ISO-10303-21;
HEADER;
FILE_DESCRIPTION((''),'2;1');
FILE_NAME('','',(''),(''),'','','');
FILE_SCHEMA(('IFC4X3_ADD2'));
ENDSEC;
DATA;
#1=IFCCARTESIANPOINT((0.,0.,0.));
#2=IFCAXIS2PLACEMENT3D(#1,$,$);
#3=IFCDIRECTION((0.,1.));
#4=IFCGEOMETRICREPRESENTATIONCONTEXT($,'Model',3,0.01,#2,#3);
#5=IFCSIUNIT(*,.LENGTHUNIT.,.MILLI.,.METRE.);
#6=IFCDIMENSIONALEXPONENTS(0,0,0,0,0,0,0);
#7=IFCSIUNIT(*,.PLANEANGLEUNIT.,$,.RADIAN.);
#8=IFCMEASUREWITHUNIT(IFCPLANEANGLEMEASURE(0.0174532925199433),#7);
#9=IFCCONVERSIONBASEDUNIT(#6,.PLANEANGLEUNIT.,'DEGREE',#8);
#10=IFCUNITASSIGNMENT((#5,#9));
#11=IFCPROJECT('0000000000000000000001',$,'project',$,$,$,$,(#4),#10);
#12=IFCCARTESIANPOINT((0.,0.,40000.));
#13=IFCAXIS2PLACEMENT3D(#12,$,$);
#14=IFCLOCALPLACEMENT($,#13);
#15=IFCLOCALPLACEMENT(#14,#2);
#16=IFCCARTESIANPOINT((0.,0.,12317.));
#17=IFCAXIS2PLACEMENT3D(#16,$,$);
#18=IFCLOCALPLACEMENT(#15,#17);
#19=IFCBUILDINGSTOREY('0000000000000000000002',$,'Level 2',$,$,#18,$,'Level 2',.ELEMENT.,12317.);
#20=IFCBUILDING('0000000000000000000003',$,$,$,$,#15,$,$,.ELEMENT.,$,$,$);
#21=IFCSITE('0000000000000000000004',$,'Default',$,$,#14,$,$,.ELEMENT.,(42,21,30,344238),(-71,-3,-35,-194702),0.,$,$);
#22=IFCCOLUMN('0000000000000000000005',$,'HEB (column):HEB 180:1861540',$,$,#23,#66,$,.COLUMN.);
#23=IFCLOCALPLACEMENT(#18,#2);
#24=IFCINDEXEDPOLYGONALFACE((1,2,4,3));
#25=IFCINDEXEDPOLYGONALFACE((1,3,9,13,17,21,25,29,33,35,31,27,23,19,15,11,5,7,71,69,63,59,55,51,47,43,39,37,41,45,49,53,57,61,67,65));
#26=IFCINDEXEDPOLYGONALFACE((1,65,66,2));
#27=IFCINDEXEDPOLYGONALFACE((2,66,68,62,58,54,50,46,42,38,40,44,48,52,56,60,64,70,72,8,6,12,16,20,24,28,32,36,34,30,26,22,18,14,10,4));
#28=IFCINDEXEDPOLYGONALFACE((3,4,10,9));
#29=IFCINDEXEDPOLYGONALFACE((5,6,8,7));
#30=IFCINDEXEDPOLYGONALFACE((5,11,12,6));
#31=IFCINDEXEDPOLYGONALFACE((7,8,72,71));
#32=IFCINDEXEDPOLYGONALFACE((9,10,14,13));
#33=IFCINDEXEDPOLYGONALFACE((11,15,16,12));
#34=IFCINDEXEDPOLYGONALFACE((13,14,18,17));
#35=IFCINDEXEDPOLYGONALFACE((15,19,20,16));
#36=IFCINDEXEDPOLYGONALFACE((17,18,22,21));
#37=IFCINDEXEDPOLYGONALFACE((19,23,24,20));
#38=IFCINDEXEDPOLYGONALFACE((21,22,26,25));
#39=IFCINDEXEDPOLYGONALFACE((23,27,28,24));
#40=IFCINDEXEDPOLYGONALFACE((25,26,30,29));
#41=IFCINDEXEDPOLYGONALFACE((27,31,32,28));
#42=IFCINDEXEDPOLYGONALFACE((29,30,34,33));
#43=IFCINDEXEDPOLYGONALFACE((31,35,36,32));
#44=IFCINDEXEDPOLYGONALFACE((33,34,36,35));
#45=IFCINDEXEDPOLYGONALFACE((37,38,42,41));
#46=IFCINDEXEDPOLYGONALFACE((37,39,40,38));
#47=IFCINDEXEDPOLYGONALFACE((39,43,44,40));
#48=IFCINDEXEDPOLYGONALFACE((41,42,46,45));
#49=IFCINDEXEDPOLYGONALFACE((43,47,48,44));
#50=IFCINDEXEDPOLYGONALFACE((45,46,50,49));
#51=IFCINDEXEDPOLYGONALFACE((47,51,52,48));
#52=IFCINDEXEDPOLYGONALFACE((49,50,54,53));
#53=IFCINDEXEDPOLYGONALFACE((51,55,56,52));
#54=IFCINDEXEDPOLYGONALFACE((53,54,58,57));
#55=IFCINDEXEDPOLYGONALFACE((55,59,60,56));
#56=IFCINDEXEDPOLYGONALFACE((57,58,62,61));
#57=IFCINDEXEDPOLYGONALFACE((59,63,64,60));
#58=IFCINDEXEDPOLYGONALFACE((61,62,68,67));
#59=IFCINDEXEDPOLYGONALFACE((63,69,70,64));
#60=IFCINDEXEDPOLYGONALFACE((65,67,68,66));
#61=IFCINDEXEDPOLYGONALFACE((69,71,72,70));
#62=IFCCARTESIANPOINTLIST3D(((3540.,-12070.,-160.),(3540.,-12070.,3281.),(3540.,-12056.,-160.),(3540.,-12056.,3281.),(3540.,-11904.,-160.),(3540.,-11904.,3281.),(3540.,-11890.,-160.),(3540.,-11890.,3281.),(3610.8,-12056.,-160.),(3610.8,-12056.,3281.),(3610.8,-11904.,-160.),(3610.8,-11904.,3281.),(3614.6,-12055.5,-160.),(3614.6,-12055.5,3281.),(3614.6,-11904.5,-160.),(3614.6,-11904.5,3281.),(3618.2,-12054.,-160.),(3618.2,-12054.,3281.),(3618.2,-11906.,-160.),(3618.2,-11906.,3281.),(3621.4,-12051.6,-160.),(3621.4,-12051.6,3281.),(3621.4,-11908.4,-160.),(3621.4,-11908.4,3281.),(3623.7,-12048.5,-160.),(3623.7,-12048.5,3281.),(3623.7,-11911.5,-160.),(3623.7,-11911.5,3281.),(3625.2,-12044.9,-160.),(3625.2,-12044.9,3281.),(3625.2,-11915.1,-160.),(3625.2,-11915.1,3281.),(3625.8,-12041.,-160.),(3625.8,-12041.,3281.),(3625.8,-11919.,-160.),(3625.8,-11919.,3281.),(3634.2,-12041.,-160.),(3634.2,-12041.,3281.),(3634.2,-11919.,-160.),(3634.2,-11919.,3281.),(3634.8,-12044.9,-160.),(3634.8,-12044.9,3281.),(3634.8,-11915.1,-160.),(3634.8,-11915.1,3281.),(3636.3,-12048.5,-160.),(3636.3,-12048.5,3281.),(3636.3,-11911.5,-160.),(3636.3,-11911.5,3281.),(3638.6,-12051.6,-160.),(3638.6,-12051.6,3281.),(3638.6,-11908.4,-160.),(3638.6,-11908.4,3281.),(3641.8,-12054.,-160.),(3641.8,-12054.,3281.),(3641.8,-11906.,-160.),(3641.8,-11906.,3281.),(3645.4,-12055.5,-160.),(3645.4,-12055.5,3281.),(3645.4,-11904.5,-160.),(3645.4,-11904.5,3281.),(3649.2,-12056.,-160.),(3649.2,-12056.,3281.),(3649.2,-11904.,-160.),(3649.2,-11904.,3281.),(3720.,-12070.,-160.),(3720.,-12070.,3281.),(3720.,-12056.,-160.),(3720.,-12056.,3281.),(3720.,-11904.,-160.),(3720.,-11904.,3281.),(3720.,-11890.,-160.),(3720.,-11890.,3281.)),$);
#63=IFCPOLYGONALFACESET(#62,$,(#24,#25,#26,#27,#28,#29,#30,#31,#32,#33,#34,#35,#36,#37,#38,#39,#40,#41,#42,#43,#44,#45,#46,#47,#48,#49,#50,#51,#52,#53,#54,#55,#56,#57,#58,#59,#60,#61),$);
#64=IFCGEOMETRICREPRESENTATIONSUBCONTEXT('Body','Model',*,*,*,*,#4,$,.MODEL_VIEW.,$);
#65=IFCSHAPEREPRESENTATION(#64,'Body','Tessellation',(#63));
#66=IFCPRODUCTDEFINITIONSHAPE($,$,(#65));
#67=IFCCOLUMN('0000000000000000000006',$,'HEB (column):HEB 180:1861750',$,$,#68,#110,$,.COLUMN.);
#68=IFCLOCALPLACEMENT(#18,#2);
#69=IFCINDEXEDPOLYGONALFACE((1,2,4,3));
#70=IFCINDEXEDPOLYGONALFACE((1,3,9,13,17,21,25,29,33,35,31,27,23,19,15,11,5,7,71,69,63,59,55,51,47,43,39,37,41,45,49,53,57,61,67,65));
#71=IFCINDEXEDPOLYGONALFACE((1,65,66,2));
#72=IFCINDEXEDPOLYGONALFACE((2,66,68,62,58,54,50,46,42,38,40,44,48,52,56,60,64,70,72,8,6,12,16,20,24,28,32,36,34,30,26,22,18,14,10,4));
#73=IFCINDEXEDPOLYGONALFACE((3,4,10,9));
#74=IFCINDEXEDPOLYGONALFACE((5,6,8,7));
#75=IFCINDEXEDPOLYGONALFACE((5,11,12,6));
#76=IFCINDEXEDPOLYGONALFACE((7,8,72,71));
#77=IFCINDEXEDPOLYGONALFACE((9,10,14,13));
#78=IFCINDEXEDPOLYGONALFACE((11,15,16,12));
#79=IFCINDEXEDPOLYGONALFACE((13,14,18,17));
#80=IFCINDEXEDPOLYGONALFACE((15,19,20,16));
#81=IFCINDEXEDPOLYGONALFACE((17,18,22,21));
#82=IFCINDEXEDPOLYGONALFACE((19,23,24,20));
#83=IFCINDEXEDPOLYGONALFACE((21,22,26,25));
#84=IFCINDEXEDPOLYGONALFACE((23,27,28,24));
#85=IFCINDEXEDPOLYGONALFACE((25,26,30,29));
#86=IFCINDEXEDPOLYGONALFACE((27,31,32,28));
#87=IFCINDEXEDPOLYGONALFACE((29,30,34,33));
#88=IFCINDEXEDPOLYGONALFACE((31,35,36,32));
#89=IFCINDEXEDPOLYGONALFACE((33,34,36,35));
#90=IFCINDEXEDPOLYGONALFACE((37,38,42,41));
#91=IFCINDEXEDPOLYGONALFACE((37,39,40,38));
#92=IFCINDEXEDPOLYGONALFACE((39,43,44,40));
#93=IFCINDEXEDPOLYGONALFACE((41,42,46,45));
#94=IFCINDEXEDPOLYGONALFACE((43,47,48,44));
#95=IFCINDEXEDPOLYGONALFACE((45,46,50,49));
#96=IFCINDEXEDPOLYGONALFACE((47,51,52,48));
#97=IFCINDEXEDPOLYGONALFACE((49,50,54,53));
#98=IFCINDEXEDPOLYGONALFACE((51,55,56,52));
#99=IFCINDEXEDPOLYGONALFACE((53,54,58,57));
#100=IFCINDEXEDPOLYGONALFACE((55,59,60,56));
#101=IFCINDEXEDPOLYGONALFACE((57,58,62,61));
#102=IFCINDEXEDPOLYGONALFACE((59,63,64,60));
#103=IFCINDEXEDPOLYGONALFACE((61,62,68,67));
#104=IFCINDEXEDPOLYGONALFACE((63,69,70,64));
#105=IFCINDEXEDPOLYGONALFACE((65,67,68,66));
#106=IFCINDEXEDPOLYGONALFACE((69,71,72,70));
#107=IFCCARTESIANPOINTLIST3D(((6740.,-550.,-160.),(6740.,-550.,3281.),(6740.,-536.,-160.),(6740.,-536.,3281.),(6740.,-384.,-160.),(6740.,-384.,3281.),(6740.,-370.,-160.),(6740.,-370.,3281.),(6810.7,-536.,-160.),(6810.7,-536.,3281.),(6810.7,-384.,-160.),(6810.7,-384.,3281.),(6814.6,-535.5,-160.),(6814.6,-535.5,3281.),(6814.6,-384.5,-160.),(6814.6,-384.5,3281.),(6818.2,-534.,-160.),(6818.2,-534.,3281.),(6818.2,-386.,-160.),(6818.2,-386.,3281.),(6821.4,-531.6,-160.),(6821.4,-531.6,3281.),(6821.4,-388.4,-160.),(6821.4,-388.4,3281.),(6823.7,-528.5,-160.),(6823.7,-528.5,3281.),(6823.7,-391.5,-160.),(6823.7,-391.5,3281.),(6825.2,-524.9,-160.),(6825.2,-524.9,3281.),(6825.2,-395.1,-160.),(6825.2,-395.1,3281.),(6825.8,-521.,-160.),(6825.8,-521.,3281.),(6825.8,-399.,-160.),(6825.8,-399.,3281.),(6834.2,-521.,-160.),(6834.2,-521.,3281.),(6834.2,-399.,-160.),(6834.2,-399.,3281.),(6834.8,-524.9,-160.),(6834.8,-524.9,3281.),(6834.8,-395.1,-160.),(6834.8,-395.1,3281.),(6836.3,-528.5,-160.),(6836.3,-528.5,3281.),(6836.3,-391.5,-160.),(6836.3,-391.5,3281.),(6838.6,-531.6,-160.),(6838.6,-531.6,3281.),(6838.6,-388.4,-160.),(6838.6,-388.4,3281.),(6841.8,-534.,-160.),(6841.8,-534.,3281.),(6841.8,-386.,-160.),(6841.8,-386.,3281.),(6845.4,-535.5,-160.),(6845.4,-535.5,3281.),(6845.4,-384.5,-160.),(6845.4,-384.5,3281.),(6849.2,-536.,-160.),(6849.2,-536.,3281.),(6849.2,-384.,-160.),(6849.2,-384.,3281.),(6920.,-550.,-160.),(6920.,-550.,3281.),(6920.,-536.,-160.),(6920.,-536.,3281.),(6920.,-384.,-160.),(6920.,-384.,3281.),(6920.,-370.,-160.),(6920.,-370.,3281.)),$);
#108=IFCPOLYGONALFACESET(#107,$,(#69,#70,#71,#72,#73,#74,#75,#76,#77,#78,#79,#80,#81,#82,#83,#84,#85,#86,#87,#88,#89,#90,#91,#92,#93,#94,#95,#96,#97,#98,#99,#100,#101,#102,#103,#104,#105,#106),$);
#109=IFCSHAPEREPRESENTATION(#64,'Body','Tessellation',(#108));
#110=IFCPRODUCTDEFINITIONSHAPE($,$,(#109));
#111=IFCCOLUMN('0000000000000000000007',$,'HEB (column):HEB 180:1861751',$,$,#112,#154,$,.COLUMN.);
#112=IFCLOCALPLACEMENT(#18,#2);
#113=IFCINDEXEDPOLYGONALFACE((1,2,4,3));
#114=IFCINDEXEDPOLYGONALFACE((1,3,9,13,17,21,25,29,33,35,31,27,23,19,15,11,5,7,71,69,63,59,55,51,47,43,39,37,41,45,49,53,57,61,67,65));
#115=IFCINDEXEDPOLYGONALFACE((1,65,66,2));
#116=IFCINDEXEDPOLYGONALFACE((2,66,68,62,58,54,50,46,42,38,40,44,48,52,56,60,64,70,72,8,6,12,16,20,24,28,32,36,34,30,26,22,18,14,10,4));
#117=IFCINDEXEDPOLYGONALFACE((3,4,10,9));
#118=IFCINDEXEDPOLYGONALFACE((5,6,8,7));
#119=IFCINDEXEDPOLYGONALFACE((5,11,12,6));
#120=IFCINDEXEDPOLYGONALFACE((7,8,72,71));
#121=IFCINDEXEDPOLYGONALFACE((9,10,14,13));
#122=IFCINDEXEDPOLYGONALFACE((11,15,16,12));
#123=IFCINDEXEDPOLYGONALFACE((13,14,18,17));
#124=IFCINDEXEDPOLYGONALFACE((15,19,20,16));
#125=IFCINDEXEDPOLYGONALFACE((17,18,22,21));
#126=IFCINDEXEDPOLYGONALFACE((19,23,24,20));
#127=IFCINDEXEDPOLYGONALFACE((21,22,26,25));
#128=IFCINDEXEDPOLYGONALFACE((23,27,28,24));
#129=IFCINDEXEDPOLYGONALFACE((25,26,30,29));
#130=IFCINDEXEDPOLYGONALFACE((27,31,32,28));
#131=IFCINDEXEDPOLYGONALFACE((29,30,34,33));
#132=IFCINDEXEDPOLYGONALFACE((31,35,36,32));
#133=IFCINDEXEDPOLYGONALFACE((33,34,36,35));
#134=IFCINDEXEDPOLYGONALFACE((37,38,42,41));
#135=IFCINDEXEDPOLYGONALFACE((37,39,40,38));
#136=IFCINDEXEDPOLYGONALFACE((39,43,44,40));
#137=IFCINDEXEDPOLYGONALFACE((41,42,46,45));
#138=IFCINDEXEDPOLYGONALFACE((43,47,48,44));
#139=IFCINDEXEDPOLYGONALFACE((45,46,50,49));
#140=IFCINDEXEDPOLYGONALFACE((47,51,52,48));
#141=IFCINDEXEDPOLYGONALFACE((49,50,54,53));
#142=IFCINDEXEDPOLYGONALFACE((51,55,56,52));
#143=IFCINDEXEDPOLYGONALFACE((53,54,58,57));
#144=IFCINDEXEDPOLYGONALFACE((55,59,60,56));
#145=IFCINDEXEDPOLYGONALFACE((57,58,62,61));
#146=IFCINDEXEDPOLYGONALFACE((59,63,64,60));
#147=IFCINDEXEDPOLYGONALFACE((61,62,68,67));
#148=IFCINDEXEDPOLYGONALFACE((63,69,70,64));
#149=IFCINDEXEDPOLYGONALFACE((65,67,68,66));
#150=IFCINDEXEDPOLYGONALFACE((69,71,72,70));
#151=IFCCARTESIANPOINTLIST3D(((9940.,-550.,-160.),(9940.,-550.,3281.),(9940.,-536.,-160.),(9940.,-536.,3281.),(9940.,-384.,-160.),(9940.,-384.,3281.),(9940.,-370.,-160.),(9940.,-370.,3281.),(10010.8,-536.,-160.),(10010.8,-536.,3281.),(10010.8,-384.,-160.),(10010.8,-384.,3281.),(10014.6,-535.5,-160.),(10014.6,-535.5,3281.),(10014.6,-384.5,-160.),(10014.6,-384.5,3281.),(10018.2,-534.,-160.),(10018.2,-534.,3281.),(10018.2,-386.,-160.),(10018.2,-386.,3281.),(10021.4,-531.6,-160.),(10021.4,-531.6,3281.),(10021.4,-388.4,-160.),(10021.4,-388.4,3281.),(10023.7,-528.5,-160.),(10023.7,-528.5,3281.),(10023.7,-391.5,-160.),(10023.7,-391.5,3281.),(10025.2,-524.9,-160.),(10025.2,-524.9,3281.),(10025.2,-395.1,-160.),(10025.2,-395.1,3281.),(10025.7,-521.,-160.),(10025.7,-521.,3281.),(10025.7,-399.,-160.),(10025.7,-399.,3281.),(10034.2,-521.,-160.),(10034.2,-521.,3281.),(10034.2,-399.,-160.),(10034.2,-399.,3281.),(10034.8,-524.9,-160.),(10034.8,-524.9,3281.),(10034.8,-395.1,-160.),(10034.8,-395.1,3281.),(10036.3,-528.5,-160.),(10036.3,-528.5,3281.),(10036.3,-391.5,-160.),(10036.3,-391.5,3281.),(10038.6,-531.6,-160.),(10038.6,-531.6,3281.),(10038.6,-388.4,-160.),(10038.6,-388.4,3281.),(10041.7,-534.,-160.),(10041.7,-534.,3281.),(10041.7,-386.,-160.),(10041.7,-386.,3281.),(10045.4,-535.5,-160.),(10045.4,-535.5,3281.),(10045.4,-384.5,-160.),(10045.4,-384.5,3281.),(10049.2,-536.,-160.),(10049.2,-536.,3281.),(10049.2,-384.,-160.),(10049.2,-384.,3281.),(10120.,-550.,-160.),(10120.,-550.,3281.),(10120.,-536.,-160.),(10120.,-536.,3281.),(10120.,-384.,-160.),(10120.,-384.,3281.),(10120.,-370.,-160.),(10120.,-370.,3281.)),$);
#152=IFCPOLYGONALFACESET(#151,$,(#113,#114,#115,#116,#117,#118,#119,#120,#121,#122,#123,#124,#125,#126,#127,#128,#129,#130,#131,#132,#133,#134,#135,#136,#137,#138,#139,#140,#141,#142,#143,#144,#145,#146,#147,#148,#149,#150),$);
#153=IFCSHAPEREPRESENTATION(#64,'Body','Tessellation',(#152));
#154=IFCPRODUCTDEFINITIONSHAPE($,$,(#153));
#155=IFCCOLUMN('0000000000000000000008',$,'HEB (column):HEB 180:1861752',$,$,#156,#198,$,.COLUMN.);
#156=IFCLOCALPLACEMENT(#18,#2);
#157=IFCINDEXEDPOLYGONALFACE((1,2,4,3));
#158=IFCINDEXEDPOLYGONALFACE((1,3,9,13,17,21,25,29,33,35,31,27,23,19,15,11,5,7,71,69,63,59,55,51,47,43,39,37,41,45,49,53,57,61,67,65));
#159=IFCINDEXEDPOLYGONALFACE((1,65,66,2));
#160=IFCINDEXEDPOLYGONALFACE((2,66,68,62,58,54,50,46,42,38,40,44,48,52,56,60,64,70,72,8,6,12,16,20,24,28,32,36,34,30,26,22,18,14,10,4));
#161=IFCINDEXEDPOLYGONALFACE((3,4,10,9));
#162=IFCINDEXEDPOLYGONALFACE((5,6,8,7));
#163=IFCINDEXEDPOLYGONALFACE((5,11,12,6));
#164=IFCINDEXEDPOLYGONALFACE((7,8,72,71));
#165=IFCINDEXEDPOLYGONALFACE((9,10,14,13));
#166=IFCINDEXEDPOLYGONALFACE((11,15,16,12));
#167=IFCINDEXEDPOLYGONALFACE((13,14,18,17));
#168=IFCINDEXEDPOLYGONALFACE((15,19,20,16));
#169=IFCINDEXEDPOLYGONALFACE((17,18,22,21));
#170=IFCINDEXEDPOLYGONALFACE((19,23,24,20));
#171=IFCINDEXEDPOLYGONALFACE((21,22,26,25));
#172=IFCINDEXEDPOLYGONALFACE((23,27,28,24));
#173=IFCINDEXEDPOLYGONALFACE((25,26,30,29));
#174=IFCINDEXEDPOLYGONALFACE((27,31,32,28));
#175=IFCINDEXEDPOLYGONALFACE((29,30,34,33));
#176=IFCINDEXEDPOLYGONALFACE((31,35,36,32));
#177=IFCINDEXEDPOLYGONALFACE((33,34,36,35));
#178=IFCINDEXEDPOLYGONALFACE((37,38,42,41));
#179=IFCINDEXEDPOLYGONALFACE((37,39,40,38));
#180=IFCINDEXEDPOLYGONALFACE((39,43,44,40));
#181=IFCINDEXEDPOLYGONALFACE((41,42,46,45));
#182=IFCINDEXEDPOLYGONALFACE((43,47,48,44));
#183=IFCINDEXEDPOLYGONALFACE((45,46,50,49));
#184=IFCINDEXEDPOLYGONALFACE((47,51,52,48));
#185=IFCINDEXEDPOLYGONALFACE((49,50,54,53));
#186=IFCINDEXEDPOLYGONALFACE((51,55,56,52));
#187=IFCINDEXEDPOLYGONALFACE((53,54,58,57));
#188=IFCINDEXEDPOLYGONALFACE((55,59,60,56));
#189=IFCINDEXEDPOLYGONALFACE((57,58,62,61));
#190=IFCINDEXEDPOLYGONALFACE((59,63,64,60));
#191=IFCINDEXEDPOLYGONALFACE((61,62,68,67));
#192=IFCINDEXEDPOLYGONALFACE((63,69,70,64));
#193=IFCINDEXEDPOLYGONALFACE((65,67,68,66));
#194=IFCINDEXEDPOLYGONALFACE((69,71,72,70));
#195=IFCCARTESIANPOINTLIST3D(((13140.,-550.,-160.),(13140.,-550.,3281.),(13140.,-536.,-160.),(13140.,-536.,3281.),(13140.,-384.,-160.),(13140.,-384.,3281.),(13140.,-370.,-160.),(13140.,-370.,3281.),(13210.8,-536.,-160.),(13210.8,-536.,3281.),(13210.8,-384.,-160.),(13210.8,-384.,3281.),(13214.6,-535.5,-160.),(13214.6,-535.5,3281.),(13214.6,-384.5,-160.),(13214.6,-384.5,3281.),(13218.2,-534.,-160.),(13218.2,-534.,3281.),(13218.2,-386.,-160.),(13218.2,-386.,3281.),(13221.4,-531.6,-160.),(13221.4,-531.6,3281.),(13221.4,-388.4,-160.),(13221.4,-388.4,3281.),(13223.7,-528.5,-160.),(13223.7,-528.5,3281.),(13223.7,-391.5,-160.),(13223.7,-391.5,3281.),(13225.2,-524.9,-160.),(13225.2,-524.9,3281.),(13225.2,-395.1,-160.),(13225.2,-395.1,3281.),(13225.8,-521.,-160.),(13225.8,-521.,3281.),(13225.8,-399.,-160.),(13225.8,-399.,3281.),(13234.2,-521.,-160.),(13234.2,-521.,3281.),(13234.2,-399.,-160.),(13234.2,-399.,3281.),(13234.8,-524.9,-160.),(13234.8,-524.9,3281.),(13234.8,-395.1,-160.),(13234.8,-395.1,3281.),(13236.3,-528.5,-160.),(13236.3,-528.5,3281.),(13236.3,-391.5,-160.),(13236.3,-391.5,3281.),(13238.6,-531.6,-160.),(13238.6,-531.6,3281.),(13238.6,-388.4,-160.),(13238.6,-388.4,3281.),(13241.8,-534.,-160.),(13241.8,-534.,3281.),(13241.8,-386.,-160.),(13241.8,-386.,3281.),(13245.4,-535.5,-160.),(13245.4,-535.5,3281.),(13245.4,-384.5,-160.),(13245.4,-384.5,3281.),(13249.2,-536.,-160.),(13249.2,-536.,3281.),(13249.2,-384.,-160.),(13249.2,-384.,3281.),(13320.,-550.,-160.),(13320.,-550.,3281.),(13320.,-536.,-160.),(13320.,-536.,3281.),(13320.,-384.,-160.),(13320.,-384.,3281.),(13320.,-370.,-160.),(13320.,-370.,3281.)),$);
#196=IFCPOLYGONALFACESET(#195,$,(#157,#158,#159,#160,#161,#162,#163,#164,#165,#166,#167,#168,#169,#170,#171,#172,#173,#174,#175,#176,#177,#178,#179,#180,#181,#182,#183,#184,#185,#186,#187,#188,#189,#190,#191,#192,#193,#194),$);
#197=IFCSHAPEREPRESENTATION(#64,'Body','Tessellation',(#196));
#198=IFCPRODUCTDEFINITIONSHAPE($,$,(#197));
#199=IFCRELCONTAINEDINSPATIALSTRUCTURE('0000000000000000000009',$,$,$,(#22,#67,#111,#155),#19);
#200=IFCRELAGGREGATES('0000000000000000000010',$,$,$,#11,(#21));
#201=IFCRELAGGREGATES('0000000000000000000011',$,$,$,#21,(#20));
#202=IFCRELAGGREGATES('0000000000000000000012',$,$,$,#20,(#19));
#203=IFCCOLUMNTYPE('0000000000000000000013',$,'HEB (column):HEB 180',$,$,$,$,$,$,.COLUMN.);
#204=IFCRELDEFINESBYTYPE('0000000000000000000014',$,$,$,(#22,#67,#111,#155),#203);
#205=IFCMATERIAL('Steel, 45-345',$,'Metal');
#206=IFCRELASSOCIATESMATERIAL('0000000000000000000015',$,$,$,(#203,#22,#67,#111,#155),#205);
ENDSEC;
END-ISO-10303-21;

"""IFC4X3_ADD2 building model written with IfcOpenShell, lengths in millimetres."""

from ifc_helpers import new_model, entity, si_unit, converted_unit, direction, frame, origin, origin_2d_with_axis, place, context, subcontext, project, spatial, i_section, extrude, source, transform, mapped, material, material_profile, profile_set, profile_usage, type_object, type_shapes, element, save


model = new_model("IFC4X3_ADD2")

# Units and contexts
model_context = context("Model", 3, precision=0.01, world=origin(), true_north=direction((0.0, 1.0)))
body_context = subcontext(model_context, "Body", "Model", "MODEL_VIEW")
ifc_project = project(units=[si_unit("LENGTHUNIT", "METRE", prefix="MILLI"), converted_unit("PLANEANGLEUNIT", "DEGREE", entity("IfcPlaneAngleMeasure", 0.0174532925199433), si_unit("PLANEANGLEUNIT", "RADIAN"), dimensions=[0, 0, 0, 0, 0, 0, 0])], contexts=[model_context])

# Site, building, storey
site_placement = place(None, frame((0.0, 0.0, 40000.0)))
site = spatial("IfcSite", under=ifc_project, at=site_placement, Name="Default", CompositionType="ELEMENT", RefLatitude=(42, 21, 30, 344238), RefLongitude=(-71, -3, -35, -194702), RefElevation=0.0)
building_placement = place(site_placement, origin())
building = spatial("IfcBuilding", under=site, at=building_placement, CompositionType="ELEMENT")
storey_placement = place(building_placement, frame((0.0, 0.0, 12317.0)))
storey = spatial("IfcBuildingStorey", under=building, at=storey_placement, Name="Level 2", LongName="Level 2", CompositionType="ELEMENT", Elevation=12317.0)

# Columns
ifc_material_1 = material(Name="Steel, 45-345", Category="Metal")
ifc_material_profile_1 = material_profile(ifc_material_1, i_section(OverallWidth=180.0, OverallDepth=180.0, WebThickness=8.5, FlangeThickness=14.0, FilletRadius=15.0, at=origin_2d_with_axis()), Name="HEB 180")
ifc_profile_set_1 = profile_set([ifc_material_profile_1], Name="HEB 180")
ifc_profile_usage_1 = profile_usage(ifc_profile_set_1)
column_type = type_object("IfcColumnType", Name="HEB (column):HEB 180", PredefinedType="COLUMN", material=ifc_profile_set_1)
shared_shape_1 = source(origin(), body_context, "Body", "SweptSolid", [
    extrude(i_section(OverallWidth=180.0, OverallDepth=180.0, WebThickness=8.5, FlangeThickness=14.0, FilletRadius=15.0, at=origin_2d_with_axis()), frame((0.0, 0.0, 12157.0), z_axis=(0.0, 0.0, 1.0), x_axis=(-1.0, 0.0, 0.0)), (0.0, 0.0, 1.0), 3441.0),
])
type_shapes(column_type, [shared_shape_1])
for number, where, name in (
    (1, (3630.0, -11980.0, -12317.0), "HEB (column):HEB 180:1861540"),
    (2, (6830.0, -460.0, -12317.0), "HEB (column):HEB 180:1861750"),
    (3, (10030.0, -460.0, -12317.0), "HEB (column):HEB 180:1861751"),
    (4, (13230.0, -460.0, -12317.0), "HEB (column):HEB 180:1861752"),
):
    element("IfcColumn", number, at=place(storey_placement, frame(where)), inside=storey, type_object=column_type, material=ifc_profile_usage_1, Name=name, PredefinedType="COLUMN", context=body_context, shape_type="MappedRepresentation", body=[
        mapped(shared_shape_1, transform((0.0, 0.0, 0.0), scale=1.0)),
    ])

save(model, "model.ifc")
